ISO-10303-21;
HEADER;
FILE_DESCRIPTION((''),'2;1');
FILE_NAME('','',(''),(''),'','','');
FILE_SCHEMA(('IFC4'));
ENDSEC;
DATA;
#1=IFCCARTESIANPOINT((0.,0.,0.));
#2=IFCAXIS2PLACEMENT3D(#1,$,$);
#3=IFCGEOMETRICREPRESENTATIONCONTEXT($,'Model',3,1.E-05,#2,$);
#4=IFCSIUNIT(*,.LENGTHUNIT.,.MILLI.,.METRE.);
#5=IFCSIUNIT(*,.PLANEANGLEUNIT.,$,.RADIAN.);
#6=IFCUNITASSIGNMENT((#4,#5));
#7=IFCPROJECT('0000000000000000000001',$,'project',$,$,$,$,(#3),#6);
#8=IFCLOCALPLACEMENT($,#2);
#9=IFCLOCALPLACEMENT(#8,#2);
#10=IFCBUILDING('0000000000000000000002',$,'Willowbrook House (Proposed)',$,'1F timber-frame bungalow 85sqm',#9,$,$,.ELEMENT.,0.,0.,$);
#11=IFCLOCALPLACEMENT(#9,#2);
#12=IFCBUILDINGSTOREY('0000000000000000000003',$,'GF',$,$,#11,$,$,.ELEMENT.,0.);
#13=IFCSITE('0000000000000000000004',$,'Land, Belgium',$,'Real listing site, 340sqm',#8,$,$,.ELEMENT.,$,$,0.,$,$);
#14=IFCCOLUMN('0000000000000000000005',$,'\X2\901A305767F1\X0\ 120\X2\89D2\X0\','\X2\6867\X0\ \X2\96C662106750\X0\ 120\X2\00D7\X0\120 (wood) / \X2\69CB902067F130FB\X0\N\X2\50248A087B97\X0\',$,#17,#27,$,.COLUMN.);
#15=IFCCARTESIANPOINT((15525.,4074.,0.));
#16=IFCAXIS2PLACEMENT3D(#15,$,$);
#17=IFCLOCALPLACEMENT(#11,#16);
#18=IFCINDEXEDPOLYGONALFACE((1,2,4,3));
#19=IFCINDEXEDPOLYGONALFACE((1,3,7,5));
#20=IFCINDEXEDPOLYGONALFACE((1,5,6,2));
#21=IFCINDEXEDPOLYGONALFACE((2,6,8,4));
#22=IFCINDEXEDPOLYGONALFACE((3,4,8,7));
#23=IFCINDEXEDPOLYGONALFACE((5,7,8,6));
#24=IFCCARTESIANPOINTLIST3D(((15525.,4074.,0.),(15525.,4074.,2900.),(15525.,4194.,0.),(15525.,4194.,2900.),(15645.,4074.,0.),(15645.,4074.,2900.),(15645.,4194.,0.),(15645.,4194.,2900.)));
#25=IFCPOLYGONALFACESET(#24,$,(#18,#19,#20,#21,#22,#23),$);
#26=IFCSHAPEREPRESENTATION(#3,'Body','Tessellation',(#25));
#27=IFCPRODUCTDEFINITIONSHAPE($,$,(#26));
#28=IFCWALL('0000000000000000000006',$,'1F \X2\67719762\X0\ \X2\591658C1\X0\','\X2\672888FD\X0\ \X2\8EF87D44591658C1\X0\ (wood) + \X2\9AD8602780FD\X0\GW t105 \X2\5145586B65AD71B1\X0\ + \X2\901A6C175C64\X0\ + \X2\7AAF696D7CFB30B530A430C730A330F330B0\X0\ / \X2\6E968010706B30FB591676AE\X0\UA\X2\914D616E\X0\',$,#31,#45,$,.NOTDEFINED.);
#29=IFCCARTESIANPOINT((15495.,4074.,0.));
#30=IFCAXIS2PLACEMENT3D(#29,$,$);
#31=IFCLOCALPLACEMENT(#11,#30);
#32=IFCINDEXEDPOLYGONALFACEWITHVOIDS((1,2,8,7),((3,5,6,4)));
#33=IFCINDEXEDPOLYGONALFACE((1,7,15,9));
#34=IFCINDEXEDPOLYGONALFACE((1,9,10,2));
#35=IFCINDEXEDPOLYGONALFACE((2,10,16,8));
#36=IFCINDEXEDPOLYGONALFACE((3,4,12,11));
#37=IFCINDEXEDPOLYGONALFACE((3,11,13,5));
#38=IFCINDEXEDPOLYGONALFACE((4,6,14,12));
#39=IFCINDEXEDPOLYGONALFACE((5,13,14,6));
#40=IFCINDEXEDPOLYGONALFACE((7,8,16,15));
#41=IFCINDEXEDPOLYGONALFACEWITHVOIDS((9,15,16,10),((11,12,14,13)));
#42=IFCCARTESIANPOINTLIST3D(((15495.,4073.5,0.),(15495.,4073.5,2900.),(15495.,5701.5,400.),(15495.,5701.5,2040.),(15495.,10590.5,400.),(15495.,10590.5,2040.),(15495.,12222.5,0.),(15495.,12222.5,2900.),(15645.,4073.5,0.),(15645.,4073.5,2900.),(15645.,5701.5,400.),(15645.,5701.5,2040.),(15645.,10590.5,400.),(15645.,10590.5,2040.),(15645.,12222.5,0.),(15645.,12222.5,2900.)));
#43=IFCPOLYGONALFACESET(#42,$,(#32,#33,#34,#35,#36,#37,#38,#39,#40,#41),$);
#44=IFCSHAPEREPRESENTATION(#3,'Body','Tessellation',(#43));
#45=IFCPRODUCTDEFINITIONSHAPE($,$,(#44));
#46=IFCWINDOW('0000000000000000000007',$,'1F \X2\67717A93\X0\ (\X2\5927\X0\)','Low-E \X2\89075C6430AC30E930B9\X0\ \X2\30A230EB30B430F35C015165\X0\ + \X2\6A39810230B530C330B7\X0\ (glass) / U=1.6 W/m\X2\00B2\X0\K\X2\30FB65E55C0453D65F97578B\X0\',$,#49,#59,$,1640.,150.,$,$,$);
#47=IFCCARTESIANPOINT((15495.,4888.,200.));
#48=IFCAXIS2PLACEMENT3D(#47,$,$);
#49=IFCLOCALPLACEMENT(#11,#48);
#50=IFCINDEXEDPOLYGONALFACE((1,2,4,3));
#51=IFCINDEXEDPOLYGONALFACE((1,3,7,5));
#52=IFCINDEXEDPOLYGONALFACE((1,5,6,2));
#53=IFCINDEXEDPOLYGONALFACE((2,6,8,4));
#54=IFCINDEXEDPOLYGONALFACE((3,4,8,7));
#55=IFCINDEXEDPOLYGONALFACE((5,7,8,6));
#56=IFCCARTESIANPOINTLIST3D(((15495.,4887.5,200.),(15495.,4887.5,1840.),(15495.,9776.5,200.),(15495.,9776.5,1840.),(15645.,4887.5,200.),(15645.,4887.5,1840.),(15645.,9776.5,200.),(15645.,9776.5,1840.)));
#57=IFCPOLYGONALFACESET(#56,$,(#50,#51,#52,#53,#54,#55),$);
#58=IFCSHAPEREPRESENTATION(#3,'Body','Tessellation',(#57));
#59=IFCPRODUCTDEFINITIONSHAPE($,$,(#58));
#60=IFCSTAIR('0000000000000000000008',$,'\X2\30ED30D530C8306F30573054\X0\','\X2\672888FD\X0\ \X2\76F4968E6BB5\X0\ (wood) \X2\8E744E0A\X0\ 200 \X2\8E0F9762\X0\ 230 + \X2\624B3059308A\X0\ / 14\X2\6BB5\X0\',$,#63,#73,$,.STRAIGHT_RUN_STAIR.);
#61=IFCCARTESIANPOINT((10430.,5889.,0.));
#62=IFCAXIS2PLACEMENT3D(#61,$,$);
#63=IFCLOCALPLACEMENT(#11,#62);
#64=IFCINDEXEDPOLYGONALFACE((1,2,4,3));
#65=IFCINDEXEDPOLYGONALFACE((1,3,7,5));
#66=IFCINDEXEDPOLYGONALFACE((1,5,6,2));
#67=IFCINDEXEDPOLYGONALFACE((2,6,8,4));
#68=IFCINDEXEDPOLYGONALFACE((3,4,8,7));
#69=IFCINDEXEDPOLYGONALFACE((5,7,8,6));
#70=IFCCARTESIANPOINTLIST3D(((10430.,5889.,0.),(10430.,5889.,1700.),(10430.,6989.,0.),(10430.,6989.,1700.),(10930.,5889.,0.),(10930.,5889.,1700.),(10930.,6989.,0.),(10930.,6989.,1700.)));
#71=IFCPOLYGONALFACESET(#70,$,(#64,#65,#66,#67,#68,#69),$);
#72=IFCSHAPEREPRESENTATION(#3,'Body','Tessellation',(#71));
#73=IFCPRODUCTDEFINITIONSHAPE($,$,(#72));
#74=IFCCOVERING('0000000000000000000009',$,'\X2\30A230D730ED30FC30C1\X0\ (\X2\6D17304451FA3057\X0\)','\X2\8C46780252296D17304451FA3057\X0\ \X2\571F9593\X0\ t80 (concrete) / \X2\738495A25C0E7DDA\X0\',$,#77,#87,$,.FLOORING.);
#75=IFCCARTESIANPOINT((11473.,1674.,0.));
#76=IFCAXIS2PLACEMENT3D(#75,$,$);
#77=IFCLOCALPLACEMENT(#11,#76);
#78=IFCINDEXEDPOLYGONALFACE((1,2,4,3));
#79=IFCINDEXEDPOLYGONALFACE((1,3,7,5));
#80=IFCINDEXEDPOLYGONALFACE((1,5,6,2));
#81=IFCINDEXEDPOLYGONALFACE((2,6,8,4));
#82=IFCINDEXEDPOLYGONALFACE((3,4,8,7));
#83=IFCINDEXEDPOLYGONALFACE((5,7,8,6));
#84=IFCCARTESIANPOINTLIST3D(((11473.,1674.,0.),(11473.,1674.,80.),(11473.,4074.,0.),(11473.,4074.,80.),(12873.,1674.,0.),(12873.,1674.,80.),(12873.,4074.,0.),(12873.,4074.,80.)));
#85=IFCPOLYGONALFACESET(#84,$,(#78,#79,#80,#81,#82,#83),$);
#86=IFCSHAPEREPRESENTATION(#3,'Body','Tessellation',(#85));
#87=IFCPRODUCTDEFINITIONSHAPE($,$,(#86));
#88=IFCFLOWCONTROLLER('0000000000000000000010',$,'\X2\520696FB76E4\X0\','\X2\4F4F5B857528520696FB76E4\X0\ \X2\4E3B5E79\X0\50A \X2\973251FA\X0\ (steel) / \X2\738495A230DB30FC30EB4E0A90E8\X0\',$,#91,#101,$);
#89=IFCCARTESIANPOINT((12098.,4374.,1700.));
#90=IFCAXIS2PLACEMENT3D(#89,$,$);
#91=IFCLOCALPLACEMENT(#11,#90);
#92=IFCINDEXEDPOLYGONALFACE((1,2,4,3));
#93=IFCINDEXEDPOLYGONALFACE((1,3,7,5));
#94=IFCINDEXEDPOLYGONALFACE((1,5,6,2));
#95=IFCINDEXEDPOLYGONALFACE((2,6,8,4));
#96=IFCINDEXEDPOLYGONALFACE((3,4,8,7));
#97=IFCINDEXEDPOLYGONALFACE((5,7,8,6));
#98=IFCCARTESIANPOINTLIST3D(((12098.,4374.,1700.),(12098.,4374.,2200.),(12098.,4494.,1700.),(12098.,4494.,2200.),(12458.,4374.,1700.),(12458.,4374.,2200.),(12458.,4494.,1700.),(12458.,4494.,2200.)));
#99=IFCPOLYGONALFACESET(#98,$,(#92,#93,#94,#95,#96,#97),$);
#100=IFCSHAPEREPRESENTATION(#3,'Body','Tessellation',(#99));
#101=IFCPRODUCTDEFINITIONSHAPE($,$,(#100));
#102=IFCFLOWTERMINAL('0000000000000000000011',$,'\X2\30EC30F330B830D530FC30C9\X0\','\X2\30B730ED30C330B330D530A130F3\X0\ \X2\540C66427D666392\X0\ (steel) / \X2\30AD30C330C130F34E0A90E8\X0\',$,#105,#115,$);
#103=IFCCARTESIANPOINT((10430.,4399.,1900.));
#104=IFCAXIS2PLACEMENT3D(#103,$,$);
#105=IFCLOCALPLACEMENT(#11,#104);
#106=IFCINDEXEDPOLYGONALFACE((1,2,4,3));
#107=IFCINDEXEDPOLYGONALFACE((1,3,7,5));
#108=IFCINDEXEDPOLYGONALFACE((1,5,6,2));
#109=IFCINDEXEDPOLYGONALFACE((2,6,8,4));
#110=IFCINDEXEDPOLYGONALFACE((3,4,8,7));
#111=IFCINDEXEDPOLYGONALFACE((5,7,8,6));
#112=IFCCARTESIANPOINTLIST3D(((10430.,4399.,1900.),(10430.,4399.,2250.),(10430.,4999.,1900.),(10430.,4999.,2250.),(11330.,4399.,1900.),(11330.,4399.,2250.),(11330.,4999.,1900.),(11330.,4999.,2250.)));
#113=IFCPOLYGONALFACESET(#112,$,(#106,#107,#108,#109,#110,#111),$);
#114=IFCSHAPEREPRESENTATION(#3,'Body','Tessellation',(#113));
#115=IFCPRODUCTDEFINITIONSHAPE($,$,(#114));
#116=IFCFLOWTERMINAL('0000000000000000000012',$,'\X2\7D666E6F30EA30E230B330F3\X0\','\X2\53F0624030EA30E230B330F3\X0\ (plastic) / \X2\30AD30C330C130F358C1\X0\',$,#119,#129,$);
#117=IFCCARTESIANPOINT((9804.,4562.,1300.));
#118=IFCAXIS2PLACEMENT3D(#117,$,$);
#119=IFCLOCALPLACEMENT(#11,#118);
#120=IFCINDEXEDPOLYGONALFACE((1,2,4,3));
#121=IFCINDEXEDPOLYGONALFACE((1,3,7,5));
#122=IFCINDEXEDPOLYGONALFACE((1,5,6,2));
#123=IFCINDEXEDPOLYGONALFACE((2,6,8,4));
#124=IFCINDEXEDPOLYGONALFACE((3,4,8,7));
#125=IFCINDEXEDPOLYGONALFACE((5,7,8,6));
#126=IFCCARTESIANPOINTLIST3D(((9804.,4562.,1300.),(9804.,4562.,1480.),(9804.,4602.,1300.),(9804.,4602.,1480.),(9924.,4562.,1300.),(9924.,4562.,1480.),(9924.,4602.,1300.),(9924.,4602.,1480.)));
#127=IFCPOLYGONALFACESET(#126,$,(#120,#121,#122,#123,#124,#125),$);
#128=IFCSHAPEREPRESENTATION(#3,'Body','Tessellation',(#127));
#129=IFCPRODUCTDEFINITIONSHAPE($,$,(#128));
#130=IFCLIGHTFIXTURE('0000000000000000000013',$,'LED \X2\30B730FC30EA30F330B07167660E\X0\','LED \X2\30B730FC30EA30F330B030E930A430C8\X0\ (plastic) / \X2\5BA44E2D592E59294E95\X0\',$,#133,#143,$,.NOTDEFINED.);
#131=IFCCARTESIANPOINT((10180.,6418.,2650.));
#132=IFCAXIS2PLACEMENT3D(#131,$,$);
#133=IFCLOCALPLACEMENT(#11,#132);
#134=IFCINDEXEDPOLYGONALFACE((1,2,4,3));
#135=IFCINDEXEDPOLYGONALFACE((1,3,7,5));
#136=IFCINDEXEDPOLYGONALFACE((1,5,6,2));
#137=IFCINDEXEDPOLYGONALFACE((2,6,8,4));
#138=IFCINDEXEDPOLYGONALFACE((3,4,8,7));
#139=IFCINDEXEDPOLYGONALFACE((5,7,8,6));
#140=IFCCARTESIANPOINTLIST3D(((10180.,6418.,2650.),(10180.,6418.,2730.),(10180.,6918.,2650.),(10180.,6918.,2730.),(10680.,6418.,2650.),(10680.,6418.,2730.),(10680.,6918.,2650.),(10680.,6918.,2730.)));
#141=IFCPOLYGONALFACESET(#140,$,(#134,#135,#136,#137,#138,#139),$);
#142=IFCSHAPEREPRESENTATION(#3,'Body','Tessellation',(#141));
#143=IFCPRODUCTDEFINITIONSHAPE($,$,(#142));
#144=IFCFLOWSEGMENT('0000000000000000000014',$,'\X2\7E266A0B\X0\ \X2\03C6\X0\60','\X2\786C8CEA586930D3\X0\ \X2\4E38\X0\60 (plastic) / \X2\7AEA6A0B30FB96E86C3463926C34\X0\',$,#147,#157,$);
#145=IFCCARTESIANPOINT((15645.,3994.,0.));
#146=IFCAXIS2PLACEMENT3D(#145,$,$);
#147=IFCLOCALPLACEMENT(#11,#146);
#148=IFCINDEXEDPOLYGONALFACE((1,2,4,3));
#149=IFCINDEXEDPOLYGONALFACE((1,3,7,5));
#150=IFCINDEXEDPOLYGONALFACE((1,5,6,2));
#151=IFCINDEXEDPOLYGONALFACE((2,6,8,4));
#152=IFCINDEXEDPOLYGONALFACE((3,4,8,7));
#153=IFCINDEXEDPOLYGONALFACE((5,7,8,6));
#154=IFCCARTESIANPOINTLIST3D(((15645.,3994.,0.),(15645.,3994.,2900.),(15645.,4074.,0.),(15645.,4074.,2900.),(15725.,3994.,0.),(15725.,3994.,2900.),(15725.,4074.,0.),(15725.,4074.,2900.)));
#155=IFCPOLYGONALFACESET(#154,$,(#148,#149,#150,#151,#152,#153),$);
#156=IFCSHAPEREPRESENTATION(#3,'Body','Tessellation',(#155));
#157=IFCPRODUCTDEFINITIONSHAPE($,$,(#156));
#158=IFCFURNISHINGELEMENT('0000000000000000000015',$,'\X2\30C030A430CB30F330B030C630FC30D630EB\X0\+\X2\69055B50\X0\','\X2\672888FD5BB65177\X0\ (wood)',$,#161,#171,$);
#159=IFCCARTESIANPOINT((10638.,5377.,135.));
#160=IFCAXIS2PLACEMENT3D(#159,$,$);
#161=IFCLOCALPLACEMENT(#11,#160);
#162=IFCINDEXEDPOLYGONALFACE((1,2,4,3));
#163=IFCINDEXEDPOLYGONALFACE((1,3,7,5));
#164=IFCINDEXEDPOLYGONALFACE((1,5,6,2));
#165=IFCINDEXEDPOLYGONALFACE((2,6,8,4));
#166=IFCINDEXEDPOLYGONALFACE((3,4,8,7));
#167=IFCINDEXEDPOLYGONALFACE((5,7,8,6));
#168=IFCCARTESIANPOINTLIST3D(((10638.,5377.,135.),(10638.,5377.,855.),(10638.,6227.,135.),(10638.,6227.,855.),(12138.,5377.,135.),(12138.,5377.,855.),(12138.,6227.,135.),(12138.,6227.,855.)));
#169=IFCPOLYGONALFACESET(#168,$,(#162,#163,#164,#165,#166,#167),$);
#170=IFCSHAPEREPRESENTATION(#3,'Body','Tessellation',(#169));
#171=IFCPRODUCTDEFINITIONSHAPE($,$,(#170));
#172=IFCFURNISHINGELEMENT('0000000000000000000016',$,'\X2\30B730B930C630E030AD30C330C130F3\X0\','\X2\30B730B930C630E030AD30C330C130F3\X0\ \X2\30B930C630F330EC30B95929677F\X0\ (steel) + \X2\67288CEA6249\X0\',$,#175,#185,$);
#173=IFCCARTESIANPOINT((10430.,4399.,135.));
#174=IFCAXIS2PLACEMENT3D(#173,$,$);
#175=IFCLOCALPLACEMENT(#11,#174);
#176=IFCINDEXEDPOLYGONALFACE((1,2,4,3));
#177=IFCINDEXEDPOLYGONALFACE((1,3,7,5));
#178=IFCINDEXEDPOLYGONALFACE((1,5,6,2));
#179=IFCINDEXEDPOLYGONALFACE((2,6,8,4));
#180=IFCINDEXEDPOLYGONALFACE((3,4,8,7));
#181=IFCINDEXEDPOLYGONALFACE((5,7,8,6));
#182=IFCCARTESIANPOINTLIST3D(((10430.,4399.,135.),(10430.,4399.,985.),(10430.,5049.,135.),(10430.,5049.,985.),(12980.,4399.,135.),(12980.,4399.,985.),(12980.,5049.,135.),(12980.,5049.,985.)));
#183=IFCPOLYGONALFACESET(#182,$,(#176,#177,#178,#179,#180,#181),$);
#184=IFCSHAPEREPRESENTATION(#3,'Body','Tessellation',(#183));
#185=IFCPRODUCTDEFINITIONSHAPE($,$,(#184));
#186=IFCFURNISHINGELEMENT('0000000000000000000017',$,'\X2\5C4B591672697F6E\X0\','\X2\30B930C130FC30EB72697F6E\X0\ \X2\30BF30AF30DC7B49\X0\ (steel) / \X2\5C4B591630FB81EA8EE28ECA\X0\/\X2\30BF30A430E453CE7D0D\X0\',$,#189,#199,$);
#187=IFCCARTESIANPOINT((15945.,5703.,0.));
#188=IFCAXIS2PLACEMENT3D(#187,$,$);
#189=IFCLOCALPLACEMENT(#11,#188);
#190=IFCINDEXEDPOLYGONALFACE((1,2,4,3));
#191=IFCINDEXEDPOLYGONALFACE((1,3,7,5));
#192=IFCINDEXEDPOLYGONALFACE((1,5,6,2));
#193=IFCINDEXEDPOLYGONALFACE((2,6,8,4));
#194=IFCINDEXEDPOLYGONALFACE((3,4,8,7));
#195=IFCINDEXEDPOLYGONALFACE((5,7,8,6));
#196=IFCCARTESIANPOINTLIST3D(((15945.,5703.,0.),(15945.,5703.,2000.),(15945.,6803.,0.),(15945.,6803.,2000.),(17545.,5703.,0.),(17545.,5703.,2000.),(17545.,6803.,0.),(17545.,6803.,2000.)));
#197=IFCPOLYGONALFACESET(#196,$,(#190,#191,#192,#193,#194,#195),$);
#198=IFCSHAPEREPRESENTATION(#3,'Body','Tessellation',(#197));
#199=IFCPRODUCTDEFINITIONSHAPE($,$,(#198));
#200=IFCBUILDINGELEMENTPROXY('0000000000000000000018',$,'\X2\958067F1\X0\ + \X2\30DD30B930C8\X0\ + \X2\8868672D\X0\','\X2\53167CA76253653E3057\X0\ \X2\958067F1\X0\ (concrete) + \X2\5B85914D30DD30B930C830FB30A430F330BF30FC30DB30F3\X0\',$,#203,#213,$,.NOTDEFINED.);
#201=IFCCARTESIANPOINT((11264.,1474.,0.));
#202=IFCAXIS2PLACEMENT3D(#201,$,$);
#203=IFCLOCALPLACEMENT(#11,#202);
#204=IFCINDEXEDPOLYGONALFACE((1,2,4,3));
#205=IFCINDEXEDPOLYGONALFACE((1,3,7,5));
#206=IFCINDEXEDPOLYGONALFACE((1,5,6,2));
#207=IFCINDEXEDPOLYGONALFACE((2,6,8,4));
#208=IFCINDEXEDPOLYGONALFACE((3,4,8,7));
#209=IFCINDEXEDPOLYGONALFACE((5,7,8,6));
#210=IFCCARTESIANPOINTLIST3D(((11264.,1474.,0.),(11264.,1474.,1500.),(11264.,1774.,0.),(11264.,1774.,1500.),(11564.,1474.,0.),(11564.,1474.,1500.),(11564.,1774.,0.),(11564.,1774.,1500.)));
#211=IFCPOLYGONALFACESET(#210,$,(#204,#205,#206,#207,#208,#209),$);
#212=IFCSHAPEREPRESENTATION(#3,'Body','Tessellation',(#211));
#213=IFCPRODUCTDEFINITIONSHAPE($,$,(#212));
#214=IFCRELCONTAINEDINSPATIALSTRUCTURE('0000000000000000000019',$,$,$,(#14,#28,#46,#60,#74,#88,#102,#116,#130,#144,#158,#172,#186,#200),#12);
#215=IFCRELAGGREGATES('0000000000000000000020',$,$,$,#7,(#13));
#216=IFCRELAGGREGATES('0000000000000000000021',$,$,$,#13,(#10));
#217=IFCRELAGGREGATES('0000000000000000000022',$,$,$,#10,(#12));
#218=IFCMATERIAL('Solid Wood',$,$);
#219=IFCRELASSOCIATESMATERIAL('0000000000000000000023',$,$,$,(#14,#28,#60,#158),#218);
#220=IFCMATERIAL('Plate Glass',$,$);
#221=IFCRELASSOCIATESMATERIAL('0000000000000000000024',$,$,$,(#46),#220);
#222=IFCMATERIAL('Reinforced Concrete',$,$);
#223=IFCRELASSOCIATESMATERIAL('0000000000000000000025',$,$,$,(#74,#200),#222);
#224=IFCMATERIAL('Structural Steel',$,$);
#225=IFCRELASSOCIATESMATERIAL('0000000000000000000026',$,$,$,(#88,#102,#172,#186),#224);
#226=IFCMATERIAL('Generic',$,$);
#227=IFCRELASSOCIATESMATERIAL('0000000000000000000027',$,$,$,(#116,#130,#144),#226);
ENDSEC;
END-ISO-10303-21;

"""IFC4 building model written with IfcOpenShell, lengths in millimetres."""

from ifc_helpers import new_model, si_unit, frame, frame_2d, origin, place, context, project, spatial, rectangle, extrude, material, element, fill, save


model = new_model("IFC4")

# Units and contexts
model_context = context("Model", 3, precision=1e-05, world=origin())
ifc_project = project(units=[si_unit("LENGTHUNIT", "METRE", prefix="MILLI"), si_unit("PLANEANGLEUNIT", "RADIAN")], contexts=[model_context])

# Site, building, storey
site_placement = place(None, origin())
site = spatial("IfcSite", under=ifc_project, at=site_placement, Name="Land, Belgium", ObjectType="Real listing site, 340sqm", CompositionType="ELEMENT", RefElevation=0.0)
building_placement = place(site_placement, origin())
building = spatial("IfcBuilding", under=site, at=building_placement, Name="Willowbrook House (Proposed)", ObjectType="1F timber-frame bungalow 85sqm", CompositionType="ELEMENT", ElevationOfRefHeight=0.0, ElevationOfTerrain=0.0)
storey_placement = place(building_placement, origin())
storey = spatial("IfcBuildingStorey", under=building, at=storey_placement, Name="GF", CompositionType="ELEMENT", Elevation=0.0)

# Column
ifc_material_1 = material(Name="Solid Wood")
column_1_placement = place(storey_placement, frame((15525.0, 4074.0, 0.0)))
element("IfcColumn", 1, at=column_1_placement, inside=storey, material=ifc_material_1, Name="通し柱 120角", Description="桧 集成材 120×120 (wood) / 構造柱・N値計算", PredefinedType="COLUMN", context=model_context, shape_type="SweptSolid", body=[
    extrude(rectangle(XDim=120.0, YDim=120.0, at=frame_2d((60.0, 60.0))), frame((15525.0, 4074.0, 0.0)), (0.0, 0.0, 1.0), 2900.0),
])

# Wall, opening, window
wall_1_placement = place(storey_placement, frame((15495.0, 4074.0, 0.0)))
wall_1 = element("IfcWall", 2, at=wall_1_placement, inside=storey, material=ifc_material_1, Name="1F 東面 外壁", Description="木製 軸組外壁 (wood) + 高性能GW t105 充填断熱 + 通気層 + 窯業系サイディング / 準耐火・外皮UA配慮", PredefinedType="NOTDEFINED", context=model_context, shape_type="SweptSolid", body=[
    extrude(rectangle(XDim=150.0, YDim=8149.0, at=frame_2d((75.0, 4074.0))), frame((15495.0, 4074.0, 0.0)), (0.0, 0.0, 1.0), 2900.0),
])
opening_placement = place(storey_placement, frame((15495.0, 4888.0, 200.0)))
opening = element("IfcOpeningElement", 3, at=opening_placement, cuts=wall_1, PredefinedType="NOTDEFINED", context=model_context, shape_type="SweptSolid", body=[
    extrude(rectangle(XDim=150.0, YDim=4889.0, at=frame_2d((75.0, 2444.0))), frame((15495.0, 4888.0, 200.0)), (0.0, 0.0, 1.0), 1640.0),
])
ifc_material_2 = material(Name="Plate Glass")
window_placement = place(storey_placement, frame((15495.0, 4888.0, 200.0)))
window = element("IfcWindow", 4, at=window_placement, inside=storey, material=ifc_material_2, Name="1F 東窓 (大)", Description="Low-E 複層ガラス アルゴン封入 + 樹脂サッシ (glass) / U=1.6 W/m²K・日射取得型", OverallHeight=1640.0, OverallWidth=150.0, context=model_context, shape_type="SweptSolid", body=[
    extrude(rectangle(XDim=150.0, YDim=4889.0, at=frame_2d((75.0, 2444.0))), frame((15495.0, 4888.0, 200.0)), (0.0, 0.0, 1.0), 1640.0),
])
fill(opening, window)

# Stair
stair_placement = place(storey_placement, frame((10430.0, 5889.0, 0.0)))
element("IfcStair", 5, at=stair_placement, inside=storey, material=ifc_material_1, Name="ロフトはしご", Description="木製 直階段 (wood) 蹴上 200 踏面 230 + 手すり / 14段", PredefinedType="STRAIGHT_RUN_STAIR", context=model_context, shape_type="SweptSolid", body=[
    extrude(rectangle(XDim=500.0, YDim=1100.0, at=frame_2d((250.0, 550.0))), frame((10430.0, 5889.0, 0.0)), (0.0, 0.0, 1.0), 1700.0),
])

# Covering
ifc_material_3 = material(Name="Reinforced Concrete")
covering_placement = place(storey_placement, frame((11473.0, 1674.0, 0.0)))
element("IfcCovering", 6, at=covering_placement, inside=storey, material=ifc_material_3, Name="アプローチ (洗い出し)", Description="豆砂利洗い出し 土間 t80 (concrete) / 玄関導線", PredefinedType="FLOORING", context=model_context, shape_type="SweptSolid", body=[
    extrude(rectangle(XDim=1400.0, YDim=2400.0, at=frame_2d((700.0, 1200.0))), frame((11473.0, 1674.0, 0.0)), (0.0, 0.0, 1.0), 80.0),
])

# Flow controller
ifc_material_4 = material(Name="Structural Steel")
flow_controller_placement = place(storey_placement, frame((12098.0, 4374.0, 1700.0)))
element("IfcFlowController", 7, at=flow_controller_placement, inside=storey, material=ifc_material_4, Name="分電盤", Description="住宅用分電盤 主幹50A 露出 (steel) / 玄関ホール上部", context=model_context, shape_type="SweptSolid", body=[
    extrude(rectangle(XDim=360.0, YDim=120.0, at=frame_2d((180.0, 60.0))), frame((12098.0, 4374.0, 1700.0)), (0.0, 0.0, 1.0), 500.0),
])

# Flow terminals
flow_terminal_1_placement = place(storey_placement, frame((10430.0, 4399.0, 1900.0)))
element("IfcFlowTerminal", 8, at=flow_terminal_1_placement, inside=storey, material=ifc_material_4, Name="レンジフード", Description="シロッコファン 同時給排 (steel) / キッチン上部", context=model_context, shape_type="SweptSolid", body=[
    extrude(rectangle(XDim=900.0, YDim=600.0, at=frame_2d((450.0, 300.0))), frame((10430.0, 4399.0, 1900.0)), (0.0, 0.0, 1.0), 350.0),
])
ifc_material_5 = material(Name="Generic")
flow_terminal_2_placement = place(storey_placement, frame((9804.0, 4562.0, 1300.0)))
element("IfcFlowTerminal", 9, at=flow_terminal_2_placement, inside=storey, material=ifc_material_5, Name="給湯リモコン", Description="台所リモコン (plastic) / キッチン壁", context=model_context, shape_type="SweptSolid", body=[
    extrude(rectangle(XDim=120.0, YDim=40.0, at=frame_2d((60.0, 20.0))), frame((9804.0, 4562.0, 1300.0)), (0.0, 0.0, 1.0), 180.0),
])

# Light fixture
light_fixture_placement = place(storey_placement, frame((10180.0, 6418.0, 2650.0)))
element("IfcLightFixture", 10, at=light_fixture_placement, inside=storey, material=ifc_material_5, Name="LED シーリング照明", Description="LED シーリングライト (plastic) / 室中央天井", PredefinedType="NOTDEFINED", context=model_context, shape_type="SweptSolid", body=[
    extrude(rectangle(XDim=500.0, YDim=500.0, at=frame_2d((250.0, 250.0))), frame((10180.0, 6418.0, 2650.0)), (0.0, 0.0, 1.0), 80.0),
])

# Flow segment
flow_segment_placement = place(storey_placement, frame((15645.0, 3994.0, 0.0)))
element("IfcFlowSegment", 11, at=flow_segment_placement, inside=storey, material=ifc_material_5, Name="縦樋 φ60", Description="硬質塩ビ 丸60 (plastic) / 竪樋・雨水排水", context=model_context, shape_type="SweptSolid", body=[
    extrude(rectangle(XDim=80.0, YDim=80.0, at=frame_2d((40.0, 40.0))), frame((15645.0, 3994.0, 0.0)), (0.0, 0.0, 1.0), 2900.0),
])

# Furnishing elements
furnishing_1_placement = place(storey_placement, frame((10638.0, 5377.0, 135.0)))
element("IfcFurnishingElement", 12, at=furnishing_1_placement, inside=storey, material=ifc_material_1, Name="ダイニングテーブル+椅子", Description="木製家具 (wood)", context=model_context, shape_type="SweptSolid", body=[
    extrude(rectangle(XDim=1500.0, YDim=850.0, at=frame_2d((750.0, 425.0))), frame((10638.0, 5377.0, 135.0)), (0.0, 0.0, 1.0), 720.0),
])
furnishing_2_placement = place(storey_placement, frame((10430.0, 4399.0, 135.0)))
element("IfcFurnishingElement", 13, at=furnishing_2_placement, inside=storey, material=ifc_material_4, Name="システムキッチン", Description="システムキッチン ステンレス天板 (steel) + 木質扉", context=model_context, shape_type="SweptSolid", body=[
    extrude(rectangle(XDim=2550.0, YDim=650.0, at=frame_2d((1275.0, 325.0))), frame((10430.0, 4399.0, 135.0)), (0.0, 0.0, 1.0), 850.0),
])
furnishing_3_placement = place(storey_placement, frame((15945.0, 5703.0, 0.0)))
element("IfcFurnishingElement", 14, at=furnishing_3_placement, inside=storey, material=ifc_material_4, Name="屋外物置", Description="スチール物置 タクボ等 (steel) / 屋外・自転車/タイヤ収納", context=model_context, shape_type="SweptSolid", body=[
    extrude(rectangle(XDim=1600.0, YDim=1100.0, at=frame_2d((800.0, 550.0))), frame((15945.0, 5703.0, 0.0)), (0.0, 0.0, 1.0), 2000.0),
])

# Building element proxy
proxy_placement = place(storey_placement, frame((11264.0, 1474.0, 0.0)))
element("IfcBuildingElementProxy", 15, at=proxy_placement, inside=storey, material=ifc_material_3, Name="門柱 + ポスト + 表札", Description="化粧打放し 門柱 (concrete) + 宅配ポスト・インターホン", PredefinedType="NOTDEFINED", context=model_context, shape_type="SweptSolid", body=[
    extrude(rectangle(XDim=300.0, YDim=300.0, at=frame_2d((150.0, 150.0))), frame((11264.0, 1474.0, 0.0)), (0.0, 0.0, 1.0), 1500.0),
])

save(model, "model.ifc")
